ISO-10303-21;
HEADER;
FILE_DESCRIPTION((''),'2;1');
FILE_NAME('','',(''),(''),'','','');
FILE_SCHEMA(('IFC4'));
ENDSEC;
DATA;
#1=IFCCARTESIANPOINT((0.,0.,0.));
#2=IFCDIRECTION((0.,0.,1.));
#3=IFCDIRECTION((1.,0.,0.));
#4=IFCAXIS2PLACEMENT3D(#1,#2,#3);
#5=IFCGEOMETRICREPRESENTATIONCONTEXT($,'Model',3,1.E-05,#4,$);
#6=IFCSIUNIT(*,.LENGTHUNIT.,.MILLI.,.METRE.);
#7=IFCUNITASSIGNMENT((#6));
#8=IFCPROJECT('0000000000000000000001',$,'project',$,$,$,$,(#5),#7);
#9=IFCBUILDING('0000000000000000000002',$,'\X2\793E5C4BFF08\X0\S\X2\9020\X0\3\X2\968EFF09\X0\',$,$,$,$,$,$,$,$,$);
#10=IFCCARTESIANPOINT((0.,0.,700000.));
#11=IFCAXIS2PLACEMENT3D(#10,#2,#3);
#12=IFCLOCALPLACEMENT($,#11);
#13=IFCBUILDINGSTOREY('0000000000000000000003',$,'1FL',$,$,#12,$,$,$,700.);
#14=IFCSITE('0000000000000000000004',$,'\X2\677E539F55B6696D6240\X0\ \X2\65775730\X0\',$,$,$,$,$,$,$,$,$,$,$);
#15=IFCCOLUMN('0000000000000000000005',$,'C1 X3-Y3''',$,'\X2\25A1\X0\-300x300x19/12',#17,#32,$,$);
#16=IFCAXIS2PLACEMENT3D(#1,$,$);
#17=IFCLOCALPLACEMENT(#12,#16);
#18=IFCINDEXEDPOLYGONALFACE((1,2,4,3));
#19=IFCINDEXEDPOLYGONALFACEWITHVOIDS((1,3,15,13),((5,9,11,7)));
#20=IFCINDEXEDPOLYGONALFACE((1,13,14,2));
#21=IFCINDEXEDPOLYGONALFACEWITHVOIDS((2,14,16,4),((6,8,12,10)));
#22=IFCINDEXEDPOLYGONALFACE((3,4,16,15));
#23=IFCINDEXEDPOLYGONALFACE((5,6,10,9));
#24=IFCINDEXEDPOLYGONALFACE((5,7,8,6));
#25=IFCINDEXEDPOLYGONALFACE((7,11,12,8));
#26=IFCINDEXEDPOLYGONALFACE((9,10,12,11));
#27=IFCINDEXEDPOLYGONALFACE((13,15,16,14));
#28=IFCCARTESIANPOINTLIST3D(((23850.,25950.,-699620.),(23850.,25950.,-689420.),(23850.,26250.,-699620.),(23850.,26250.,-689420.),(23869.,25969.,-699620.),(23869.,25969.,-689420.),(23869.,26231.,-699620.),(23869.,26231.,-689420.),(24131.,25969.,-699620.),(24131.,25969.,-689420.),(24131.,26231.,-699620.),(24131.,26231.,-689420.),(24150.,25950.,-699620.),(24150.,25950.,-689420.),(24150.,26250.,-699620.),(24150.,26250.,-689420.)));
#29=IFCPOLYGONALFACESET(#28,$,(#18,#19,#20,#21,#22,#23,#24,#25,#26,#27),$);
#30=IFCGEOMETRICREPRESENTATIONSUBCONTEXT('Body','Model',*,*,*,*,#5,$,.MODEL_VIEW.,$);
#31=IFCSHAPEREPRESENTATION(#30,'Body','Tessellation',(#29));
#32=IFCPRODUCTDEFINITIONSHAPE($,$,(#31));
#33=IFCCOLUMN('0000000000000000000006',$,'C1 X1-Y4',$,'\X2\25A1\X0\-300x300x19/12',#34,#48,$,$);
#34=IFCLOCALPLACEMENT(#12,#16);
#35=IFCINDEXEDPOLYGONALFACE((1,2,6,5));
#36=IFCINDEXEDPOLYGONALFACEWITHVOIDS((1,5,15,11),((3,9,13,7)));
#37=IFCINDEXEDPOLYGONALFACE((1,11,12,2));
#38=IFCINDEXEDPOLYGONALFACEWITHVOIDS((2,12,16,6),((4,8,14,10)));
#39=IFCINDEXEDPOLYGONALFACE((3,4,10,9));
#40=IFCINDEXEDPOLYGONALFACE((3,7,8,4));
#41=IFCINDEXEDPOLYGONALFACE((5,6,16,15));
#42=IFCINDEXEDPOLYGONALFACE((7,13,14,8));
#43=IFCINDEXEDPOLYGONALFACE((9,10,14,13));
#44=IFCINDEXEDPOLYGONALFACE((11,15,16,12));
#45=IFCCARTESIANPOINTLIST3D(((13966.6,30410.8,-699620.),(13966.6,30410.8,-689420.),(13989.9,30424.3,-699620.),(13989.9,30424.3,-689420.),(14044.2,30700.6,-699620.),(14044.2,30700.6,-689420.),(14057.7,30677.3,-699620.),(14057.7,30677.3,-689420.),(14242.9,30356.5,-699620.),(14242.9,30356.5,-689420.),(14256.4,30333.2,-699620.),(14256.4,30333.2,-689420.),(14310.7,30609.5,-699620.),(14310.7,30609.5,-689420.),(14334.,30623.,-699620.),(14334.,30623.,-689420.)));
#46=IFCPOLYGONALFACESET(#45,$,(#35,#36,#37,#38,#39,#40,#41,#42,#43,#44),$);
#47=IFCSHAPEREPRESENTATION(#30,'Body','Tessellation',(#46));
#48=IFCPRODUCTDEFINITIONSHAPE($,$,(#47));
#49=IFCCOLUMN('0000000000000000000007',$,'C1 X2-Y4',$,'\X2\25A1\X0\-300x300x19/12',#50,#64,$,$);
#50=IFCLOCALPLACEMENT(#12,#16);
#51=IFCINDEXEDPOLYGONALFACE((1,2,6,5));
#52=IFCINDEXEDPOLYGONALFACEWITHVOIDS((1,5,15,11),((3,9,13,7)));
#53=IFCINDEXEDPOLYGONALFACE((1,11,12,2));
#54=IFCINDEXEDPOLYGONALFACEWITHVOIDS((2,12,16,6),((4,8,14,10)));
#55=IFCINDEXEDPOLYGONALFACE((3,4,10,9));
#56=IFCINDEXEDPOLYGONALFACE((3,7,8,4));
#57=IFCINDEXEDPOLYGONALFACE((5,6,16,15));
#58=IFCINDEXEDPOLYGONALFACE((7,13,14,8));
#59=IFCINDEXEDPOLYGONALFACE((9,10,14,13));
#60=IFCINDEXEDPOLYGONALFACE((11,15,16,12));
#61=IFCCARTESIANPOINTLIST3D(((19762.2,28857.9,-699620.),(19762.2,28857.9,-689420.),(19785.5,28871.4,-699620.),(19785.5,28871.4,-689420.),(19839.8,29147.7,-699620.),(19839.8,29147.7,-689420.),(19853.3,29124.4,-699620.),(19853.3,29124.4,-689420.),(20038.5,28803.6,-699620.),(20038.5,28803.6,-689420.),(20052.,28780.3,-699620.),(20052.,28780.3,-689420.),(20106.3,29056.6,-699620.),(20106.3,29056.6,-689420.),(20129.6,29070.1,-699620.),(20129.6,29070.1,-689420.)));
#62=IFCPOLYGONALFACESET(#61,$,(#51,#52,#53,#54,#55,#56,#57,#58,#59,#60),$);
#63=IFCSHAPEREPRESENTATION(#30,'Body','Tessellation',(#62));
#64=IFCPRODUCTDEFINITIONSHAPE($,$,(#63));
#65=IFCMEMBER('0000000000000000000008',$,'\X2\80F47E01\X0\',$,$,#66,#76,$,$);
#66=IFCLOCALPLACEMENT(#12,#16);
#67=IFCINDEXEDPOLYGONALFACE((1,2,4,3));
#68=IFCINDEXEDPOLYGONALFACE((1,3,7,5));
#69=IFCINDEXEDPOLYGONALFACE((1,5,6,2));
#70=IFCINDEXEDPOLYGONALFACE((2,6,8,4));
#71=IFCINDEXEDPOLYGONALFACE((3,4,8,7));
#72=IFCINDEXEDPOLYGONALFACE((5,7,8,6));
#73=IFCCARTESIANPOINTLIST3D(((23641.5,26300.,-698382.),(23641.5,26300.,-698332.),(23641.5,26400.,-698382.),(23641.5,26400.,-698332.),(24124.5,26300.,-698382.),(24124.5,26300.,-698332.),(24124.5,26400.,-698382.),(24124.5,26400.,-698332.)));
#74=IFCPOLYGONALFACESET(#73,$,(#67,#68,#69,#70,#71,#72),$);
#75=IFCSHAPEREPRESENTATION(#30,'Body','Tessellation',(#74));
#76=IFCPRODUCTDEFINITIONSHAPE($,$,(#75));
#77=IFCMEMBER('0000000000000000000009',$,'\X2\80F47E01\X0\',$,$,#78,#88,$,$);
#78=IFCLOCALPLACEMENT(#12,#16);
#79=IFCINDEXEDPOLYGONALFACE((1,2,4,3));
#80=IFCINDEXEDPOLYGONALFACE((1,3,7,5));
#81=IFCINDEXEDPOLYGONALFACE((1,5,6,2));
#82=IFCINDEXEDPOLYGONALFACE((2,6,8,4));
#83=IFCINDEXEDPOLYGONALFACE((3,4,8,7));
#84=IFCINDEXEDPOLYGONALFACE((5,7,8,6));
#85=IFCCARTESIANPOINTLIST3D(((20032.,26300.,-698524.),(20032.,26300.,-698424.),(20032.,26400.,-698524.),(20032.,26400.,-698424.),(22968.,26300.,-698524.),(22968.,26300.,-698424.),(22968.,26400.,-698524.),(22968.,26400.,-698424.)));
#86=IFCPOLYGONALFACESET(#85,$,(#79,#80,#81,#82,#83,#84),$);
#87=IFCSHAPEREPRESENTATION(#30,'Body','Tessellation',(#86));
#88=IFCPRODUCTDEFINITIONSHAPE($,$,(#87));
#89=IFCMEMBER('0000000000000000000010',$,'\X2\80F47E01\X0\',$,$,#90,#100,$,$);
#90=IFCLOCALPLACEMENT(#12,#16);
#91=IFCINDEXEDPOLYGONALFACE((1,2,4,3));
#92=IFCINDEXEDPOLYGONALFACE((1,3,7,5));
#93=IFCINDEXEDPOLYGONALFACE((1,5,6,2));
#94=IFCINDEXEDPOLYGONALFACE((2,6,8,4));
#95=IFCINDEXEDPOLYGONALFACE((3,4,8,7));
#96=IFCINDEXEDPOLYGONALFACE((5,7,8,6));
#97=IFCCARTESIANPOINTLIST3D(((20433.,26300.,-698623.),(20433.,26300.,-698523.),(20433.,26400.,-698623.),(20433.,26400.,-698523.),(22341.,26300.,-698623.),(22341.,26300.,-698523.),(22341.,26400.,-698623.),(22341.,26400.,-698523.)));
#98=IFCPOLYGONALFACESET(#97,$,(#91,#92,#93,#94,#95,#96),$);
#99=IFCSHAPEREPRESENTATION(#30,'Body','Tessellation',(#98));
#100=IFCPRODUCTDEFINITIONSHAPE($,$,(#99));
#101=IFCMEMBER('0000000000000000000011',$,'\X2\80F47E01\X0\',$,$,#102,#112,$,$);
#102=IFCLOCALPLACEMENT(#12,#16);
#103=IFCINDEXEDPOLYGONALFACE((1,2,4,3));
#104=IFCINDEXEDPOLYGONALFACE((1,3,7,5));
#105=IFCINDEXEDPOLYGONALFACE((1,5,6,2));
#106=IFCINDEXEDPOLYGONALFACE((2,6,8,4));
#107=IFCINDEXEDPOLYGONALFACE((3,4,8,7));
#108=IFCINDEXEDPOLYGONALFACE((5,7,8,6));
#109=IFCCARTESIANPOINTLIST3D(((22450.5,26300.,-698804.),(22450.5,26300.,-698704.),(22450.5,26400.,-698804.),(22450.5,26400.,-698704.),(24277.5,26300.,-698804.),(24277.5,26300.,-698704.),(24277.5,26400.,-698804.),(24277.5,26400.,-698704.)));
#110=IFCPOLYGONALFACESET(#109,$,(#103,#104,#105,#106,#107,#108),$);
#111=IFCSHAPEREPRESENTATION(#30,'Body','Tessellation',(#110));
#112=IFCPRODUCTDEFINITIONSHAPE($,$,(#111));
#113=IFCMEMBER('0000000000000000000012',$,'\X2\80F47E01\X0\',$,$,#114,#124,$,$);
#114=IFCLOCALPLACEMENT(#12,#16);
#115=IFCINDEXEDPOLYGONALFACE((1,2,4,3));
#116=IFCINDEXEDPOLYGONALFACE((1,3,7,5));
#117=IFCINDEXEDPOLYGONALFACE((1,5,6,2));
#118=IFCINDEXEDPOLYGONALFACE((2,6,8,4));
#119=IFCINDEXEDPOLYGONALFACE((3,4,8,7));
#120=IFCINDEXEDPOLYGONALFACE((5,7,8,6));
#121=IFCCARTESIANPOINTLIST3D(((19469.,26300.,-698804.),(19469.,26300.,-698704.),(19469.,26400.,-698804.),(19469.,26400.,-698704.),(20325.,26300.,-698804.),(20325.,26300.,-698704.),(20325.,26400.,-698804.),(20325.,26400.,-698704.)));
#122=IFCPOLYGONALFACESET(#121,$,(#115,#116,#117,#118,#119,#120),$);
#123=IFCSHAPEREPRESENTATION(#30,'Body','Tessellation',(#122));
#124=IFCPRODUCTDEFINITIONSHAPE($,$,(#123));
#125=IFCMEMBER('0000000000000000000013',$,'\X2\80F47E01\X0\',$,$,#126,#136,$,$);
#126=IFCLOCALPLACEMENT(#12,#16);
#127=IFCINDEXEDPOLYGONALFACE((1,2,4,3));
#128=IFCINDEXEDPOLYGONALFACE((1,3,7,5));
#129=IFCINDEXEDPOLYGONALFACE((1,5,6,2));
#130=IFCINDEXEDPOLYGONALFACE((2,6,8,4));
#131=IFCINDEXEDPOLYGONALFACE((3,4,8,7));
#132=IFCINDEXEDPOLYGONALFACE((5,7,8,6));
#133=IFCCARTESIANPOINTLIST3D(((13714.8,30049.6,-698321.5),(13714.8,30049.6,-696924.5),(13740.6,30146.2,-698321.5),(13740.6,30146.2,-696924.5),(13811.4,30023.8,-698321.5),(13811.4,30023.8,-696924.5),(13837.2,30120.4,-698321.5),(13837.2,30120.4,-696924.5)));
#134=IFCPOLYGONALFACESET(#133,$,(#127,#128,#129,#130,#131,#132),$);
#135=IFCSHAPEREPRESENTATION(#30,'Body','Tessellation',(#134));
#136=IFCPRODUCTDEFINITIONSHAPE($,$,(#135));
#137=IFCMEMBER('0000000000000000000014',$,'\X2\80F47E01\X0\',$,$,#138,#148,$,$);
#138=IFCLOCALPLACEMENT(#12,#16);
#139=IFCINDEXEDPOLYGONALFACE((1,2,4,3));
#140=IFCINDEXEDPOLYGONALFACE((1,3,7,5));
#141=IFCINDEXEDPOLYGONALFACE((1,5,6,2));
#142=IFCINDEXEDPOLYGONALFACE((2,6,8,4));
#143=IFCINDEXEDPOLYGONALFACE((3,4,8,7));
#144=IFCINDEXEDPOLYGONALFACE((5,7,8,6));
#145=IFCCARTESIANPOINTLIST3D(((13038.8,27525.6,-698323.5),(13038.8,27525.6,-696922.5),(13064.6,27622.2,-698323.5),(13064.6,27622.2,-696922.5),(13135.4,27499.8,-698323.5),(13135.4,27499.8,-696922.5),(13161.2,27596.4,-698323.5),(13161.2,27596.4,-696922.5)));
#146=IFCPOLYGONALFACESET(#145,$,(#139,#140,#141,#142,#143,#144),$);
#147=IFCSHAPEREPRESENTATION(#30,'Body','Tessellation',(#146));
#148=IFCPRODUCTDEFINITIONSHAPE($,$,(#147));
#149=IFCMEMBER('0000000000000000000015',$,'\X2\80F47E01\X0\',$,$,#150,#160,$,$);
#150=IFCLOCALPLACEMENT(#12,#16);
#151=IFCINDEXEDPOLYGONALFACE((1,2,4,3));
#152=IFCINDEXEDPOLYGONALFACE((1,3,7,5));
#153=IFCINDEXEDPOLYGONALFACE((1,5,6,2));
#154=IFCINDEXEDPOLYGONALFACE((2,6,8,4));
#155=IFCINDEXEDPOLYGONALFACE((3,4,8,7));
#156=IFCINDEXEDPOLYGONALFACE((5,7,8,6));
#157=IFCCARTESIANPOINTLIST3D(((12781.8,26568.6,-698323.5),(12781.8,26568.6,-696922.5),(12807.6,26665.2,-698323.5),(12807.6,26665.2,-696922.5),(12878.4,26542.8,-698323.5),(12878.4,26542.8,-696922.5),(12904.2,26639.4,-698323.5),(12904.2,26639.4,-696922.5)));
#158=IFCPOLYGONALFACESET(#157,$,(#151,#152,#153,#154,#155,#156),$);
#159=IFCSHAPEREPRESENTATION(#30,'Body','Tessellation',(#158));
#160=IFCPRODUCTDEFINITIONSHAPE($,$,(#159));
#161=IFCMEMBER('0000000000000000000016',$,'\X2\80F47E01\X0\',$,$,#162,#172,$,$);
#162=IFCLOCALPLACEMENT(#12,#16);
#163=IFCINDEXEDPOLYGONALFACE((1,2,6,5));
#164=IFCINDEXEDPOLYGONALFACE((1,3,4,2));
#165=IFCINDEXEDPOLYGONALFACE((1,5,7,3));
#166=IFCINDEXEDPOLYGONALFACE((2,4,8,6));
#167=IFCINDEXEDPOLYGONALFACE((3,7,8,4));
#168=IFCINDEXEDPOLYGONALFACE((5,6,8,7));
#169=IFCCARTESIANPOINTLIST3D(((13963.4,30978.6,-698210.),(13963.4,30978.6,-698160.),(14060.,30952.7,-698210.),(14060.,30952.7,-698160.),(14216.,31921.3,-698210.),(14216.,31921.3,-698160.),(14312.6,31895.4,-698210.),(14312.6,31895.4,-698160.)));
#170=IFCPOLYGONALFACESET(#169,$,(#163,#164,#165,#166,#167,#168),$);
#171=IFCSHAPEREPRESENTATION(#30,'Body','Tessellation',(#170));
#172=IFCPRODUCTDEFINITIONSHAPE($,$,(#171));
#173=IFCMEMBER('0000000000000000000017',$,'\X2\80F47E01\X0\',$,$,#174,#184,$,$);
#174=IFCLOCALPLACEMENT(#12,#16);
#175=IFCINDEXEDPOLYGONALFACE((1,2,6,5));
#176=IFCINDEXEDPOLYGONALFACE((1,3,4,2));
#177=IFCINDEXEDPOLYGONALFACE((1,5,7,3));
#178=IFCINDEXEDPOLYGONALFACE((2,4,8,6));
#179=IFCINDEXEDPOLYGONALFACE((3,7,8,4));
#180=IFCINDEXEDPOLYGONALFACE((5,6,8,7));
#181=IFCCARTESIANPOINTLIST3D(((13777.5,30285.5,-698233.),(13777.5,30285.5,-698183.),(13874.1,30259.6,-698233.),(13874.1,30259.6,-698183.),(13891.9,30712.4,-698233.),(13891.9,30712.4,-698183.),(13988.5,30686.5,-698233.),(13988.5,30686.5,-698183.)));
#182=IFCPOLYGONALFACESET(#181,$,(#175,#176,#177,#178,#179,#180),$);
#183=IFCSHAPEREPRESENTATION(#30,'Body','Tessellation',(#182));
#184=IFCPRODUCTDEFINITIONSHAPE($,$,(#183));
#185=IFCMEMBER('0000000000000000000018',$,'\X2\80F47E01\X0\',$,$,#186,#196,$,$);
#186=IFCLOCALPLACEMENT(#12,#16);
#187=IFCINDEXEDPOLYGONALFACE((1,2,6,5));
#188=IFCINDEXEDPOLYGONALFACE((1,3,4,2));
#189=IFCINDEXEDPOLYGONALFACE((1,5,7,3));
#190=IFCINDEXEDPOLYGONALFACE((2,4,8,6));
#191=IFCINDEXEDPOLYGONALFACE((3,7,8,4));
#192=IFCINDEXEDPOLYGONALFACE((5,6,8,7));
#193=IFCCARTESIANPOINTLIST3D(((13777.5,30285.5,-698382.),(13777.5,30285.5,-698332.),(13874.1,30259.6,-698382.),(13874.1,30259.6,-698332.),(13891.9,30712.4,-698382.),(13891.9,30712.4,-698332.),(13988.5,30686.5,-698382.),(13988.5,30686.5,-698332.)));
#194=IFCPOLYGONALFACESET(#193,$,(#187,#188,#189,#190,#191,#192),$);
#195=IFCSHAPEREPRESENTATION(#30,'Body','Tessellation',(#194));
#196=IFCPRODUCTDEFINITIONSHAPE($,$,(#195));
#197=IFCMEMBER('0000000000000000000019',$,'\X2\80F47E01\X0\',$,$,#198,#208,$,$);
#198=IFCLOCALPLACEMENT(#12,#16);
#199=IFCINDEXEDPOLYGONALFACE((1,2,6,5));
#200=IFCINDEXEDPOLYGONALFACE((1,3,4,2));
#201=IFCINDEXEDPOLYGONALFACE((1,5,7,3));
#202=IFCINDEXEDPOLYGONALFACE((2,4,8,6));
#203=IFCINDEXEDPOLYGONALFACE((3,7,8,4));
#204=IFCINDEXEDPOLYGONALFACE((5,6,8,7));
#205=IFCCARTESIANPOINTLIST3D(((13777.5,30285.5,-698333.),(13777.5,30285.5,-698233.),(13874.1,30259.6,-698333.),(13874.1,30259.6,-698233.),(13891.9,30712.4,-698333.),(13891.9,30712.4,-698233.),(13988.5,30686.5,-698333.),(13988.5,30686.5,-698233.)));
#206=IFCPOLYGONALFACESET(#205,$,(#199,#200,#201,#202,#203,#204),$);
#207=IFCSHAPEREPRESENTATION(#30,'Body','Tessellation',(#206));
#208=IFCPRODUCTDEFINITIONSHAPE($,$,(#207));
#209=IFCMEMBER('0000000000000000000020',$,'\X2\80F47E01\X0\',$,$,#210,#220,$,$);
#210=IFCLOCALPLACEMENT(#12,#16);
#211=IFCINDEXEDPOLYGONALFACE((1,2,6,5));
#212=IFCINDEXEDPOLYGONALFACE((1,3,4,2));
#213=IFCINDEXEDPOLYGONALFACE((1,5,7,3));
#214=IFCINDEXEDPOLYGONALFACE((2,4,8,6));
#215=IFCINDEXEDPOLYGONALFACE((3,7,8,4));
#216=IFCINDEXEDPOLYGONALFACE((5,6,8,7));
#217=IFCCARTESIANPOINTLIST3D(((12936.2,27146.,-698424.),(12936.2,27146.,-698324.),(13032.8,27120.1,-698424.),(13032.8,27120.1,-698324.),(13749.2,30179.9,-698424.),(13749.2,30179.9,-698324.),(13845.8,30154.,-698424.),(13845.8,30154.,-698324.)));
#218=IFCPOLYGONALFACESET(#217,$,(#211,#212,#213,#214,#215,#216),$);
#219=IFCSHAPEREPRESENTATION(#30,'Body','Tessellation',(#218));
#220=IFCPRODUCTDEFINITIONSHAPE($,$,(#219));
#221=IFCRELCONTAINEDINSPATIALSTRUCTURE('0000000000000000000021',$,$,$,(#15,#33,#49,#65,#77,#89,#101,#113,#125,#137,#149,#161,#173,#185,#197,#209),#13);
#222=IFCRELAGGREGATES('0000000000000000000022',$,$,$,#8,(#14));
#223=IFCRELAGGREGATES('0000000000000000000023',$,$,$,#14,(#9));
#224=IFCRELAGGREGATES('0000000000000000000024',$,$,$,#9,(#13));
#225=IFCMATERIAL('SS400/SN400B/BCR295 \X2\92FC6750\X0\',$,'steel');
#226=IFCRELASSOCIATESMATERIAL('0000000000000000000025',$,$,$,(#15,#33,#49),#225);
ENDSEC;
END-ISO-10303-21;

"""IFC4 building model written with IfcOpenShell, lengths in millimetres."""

from ifc_helpers import new_model, si_unit, frame, origin, origin_with_axes, place, context, subcontext, project, spatial, rectangle, hollow_rectangle, extrude, material, element, save


model = new_model("IFC4")

# Units and contexts
model_context = context("Model", 3, precision=1e-05, world=origin_with_axes())
body_context = subcontext(model_context, "Body", "Model", "MODEL_VIEW")
ifc_project = project(units=[si_unit("LENGTHUNIT", "METRE", prefix="MILLI")], contexts=[model_context])

# Site, building, storey
site = spatial("IfcSite", under=ifc_project, Name="松原営業所 敷地")
building = spatial("IfcBuilding", under=site, Name="社屋（S造3階）")
storey_placement = place(None, frame((0.0, 0.0, 700000.0), z_axis=(0.0, 0.0, 1.0), x_axis=(1.0, 0.0, 0.0)))
storey = spatial("IfcBuildingStorey", under=building, at=storey_placement, Name="1FL", Elevation=700.0)

# Columns
ifc_material = material(Name="SS400/SN400B/BCR295 鋼材", Category="steel")
for number, where, z_axis, x_axis, name in (
    (1, (24000.0, 26100.0, -699620.0), (0.0, 0.0, 1.0), (1.0, 0.0, 0.0), "C1 X3-Y3'"),
    (2, (14150.3, 30516.9, -699620.0), (0.0, 0.0, 1.0), (0.965926, -0.258819, 0.0), "C1 X1-Y4"),
    (3, (19945.9, 28964.0, -699620.0), (0.0, 0.0, 1.0), (0.965926, -0.258819, 0.0), "C1 X2-Y4"),
):
    element("IfcColumn", number, at=place(storey_placement, frame(where, z_axis=z_axis, x_axis=x_axis)), inside=storey, material=ifc_material, Name=name, ObjectType="□-300x300x19/12", context=body_context, shape_type="SweptSolid", body=[
        extrude(hollow_rectangle(XDim=300.0, YDim=300.0, WallThickness=19.0), origin(), (0.0, 0.0, 1.0), 10200.0),
    ])

# Members
member_1_placement = place(storey_placement, frame((24124.5, 26350.0, -698357.0), z_axis=(-1.0, 0.0, 0.0), x_axis=(0.0, -1.0, 0.0)))
element("IfcMember", 4, at=member_1_placement, inside=storey, Name="胴縁", context=body_context, shape_type="SweptSolid", body=[
    extrude(rectangle(XDim=100.0, YDim=50.0), origin(), (0.0, 0.0, 1.0), 483.0),
])
member_2_placement = place(storey_placement, frame((22968.0, 26350.0, -698474.0), z_axis=(-1.0, 0.0, 0.0), x_axis=(0.0, -1.0, 0.0)))
element("IfcMember", 5, at=member_2_placement, inside=storey, Name="胴縁", context=body_context, shape_type="SweptSolid", body=[
    extrude(rectangle(XDim=100.0, YDim=100.0), origin(), (0.0, 0.0, 1.0), 2936.0),
])
member_3_placement = place(storey_placement, frame((22341.0, 26350.0, -698573.0), z_axis=(-1.0, 0.0, 0.0), x_axis=(0.0, -1.0, 0.0)))
element("IfcMember", 6, at=member_3_placement, inside=storey, Name="胴縁", context=body_context, shape_type="SweptSolid", body=[
    extrude(rectangle(XDim=100.0, YDim=100.0), origin(), (0.0, 0.0, 1.0), 1908.0),
])
member_4_placement = place(storey_placement, frame((24277.5, 26350.0, -698754.0), z_axis=(-1.0, 0.0, 0.0), x_axis=(0.0, -1.0, 0.0)))
element("IfcMember", 7, at=member_4_placement, inside=storey, Name="胴縁", context=body_context, shape_type="SweptSolid", body=[
    extrude(rectangle(XDim=100.0, YDim=100.0), origin(), (0.0, 0.0, 1.0), 1827.0),
])
member_5_placement = place(storey_placement, frame((20325.0, 26350.0, -698754.0), z_axis=(-1.0, 0.0, 0.0), x_axis=(0.0, -1.0, 0.0)))
element("IfcMember", 8, at=member_5_placement, inside=storey, Name="胴縁", context=body_context, shape_type="SweptSolid", body=[
    extrude(rectangle(XDim=100.0, YDim=100.0), origin(), (0.0, 0.0, 1.0), 856.0),
])
member_6_placement = place(storey_placement, frame((13788.9, 30133.3, -697623.0), z_axis=(-0.258819, -0.965926, 0.0), x_axis=(0.965926, -0.258819, 0.0)))
element("IfcMember", 9, at=member_6_placement, inside=storey, Name="胴縁", context=body_context, shape_type="SweptSolid", body=[
    extrude(rectangle(XDim=100.0, YDim=1397.0), origin(), (0.0, 0.0, 1.0), 100.0),
])
for number, where, z_axis, x_axis, name in (
    (10, (13112.9, 27609.3, -697623.0), (-0.258819, -0.965926, 0.0), (0.965926, -0.258819, 0.0), "胴縁"),
    (11, (12855.9, 26652.3, -697623.0), (-0.258819, -0.965926, 0.0), (0.965926, -0.258819, 0.0), "胴縁"),
):
    element("IfcMember", number, at=place(storey_placement, frame(where, z_axis=z_axis, x_axis=x_axis)), inside=storey, Name=name, context=body_context, shape_type="SweptSolid", body=[
        extrude(rectangle(XDim=100.0, YDim=1401.0), origin(), (0.0, 0.0, 1.0), 100.0),
    ])
member_7_placement = place(storey_placement, frame((14264.3, 31908.4, -698185.0), z_axis=(-0.258819, -0.965926, 0.0), x_axis=(0.965926, -0.258819, 0.0)))
element("IfcMember", 12, at=member_7_placement, inside=storey, Name="胴縁", context=body_context, shape_type="SweptSolid", body=[
    extrude(rectangle(XDim=100.0, YDim=50.0), origin(), (0.0, 0.0, 1.0), 976.0),
])
for number, where, z_axis, x_axis, name in (
    (13, (13940.2, 30699.5, -698208.0), (-0.258819, -0.965926, 0.0), (0.965926, -0.258819, 0.0), "胴縁"),
    (14, (13940.2, 30699.5, -698357.0), (-0.258819, -0.965926, 0.0), (0.965926, -0.258819, 0.0), "胴縁"),
):
    element("IfcMember", number, at=place(storey_placement, frame(where, z_axis=z_axis, x_axis=x_axis)), inside=storey, Name=name, context=body_context, shape_type="SweptSolid", body=[
        extrude(rectangle(XDim=100.0, YDim=50.0), origin(), (0.0, 0.0, 1.0), 442.0),
    ])
member_8_placement = place(storey_placement, frame((13940.2, 30699.5, -698283.0), z_axis=(-0.258819, -0.965926, 0.0), x_axis=(0.965926, -0.258819, 0.0)))
element("IfcMember", 15, at=member_8_placement, inside=storey, Name="胴縁", context=body_context, shape_type="SweptSolid", body=[
    extrude(rectangle(XDim=100.0, YDim=100.0), origin(), (0.0, 0.0, 1.0), 442.0),
])
member_9_placement = place(storey_placement, frame((13797.5, 30167.0, -698374.0), z_axis=(-0.258819, -0.965926, 0.0), x_axis=(0.965926, -0.258819, 0.0)))
element("IfcMember", 16, at=member_9_placement, inside=storey, Name="胴縁", context=body_context, shape_type="SweptSolid", body=[
    extrude(rectangle(XDim=100.0, YDim=100.0), origin(), (0.0, 0.0, 1.0), 3141.0),
])

save(model, "model.ifc")
